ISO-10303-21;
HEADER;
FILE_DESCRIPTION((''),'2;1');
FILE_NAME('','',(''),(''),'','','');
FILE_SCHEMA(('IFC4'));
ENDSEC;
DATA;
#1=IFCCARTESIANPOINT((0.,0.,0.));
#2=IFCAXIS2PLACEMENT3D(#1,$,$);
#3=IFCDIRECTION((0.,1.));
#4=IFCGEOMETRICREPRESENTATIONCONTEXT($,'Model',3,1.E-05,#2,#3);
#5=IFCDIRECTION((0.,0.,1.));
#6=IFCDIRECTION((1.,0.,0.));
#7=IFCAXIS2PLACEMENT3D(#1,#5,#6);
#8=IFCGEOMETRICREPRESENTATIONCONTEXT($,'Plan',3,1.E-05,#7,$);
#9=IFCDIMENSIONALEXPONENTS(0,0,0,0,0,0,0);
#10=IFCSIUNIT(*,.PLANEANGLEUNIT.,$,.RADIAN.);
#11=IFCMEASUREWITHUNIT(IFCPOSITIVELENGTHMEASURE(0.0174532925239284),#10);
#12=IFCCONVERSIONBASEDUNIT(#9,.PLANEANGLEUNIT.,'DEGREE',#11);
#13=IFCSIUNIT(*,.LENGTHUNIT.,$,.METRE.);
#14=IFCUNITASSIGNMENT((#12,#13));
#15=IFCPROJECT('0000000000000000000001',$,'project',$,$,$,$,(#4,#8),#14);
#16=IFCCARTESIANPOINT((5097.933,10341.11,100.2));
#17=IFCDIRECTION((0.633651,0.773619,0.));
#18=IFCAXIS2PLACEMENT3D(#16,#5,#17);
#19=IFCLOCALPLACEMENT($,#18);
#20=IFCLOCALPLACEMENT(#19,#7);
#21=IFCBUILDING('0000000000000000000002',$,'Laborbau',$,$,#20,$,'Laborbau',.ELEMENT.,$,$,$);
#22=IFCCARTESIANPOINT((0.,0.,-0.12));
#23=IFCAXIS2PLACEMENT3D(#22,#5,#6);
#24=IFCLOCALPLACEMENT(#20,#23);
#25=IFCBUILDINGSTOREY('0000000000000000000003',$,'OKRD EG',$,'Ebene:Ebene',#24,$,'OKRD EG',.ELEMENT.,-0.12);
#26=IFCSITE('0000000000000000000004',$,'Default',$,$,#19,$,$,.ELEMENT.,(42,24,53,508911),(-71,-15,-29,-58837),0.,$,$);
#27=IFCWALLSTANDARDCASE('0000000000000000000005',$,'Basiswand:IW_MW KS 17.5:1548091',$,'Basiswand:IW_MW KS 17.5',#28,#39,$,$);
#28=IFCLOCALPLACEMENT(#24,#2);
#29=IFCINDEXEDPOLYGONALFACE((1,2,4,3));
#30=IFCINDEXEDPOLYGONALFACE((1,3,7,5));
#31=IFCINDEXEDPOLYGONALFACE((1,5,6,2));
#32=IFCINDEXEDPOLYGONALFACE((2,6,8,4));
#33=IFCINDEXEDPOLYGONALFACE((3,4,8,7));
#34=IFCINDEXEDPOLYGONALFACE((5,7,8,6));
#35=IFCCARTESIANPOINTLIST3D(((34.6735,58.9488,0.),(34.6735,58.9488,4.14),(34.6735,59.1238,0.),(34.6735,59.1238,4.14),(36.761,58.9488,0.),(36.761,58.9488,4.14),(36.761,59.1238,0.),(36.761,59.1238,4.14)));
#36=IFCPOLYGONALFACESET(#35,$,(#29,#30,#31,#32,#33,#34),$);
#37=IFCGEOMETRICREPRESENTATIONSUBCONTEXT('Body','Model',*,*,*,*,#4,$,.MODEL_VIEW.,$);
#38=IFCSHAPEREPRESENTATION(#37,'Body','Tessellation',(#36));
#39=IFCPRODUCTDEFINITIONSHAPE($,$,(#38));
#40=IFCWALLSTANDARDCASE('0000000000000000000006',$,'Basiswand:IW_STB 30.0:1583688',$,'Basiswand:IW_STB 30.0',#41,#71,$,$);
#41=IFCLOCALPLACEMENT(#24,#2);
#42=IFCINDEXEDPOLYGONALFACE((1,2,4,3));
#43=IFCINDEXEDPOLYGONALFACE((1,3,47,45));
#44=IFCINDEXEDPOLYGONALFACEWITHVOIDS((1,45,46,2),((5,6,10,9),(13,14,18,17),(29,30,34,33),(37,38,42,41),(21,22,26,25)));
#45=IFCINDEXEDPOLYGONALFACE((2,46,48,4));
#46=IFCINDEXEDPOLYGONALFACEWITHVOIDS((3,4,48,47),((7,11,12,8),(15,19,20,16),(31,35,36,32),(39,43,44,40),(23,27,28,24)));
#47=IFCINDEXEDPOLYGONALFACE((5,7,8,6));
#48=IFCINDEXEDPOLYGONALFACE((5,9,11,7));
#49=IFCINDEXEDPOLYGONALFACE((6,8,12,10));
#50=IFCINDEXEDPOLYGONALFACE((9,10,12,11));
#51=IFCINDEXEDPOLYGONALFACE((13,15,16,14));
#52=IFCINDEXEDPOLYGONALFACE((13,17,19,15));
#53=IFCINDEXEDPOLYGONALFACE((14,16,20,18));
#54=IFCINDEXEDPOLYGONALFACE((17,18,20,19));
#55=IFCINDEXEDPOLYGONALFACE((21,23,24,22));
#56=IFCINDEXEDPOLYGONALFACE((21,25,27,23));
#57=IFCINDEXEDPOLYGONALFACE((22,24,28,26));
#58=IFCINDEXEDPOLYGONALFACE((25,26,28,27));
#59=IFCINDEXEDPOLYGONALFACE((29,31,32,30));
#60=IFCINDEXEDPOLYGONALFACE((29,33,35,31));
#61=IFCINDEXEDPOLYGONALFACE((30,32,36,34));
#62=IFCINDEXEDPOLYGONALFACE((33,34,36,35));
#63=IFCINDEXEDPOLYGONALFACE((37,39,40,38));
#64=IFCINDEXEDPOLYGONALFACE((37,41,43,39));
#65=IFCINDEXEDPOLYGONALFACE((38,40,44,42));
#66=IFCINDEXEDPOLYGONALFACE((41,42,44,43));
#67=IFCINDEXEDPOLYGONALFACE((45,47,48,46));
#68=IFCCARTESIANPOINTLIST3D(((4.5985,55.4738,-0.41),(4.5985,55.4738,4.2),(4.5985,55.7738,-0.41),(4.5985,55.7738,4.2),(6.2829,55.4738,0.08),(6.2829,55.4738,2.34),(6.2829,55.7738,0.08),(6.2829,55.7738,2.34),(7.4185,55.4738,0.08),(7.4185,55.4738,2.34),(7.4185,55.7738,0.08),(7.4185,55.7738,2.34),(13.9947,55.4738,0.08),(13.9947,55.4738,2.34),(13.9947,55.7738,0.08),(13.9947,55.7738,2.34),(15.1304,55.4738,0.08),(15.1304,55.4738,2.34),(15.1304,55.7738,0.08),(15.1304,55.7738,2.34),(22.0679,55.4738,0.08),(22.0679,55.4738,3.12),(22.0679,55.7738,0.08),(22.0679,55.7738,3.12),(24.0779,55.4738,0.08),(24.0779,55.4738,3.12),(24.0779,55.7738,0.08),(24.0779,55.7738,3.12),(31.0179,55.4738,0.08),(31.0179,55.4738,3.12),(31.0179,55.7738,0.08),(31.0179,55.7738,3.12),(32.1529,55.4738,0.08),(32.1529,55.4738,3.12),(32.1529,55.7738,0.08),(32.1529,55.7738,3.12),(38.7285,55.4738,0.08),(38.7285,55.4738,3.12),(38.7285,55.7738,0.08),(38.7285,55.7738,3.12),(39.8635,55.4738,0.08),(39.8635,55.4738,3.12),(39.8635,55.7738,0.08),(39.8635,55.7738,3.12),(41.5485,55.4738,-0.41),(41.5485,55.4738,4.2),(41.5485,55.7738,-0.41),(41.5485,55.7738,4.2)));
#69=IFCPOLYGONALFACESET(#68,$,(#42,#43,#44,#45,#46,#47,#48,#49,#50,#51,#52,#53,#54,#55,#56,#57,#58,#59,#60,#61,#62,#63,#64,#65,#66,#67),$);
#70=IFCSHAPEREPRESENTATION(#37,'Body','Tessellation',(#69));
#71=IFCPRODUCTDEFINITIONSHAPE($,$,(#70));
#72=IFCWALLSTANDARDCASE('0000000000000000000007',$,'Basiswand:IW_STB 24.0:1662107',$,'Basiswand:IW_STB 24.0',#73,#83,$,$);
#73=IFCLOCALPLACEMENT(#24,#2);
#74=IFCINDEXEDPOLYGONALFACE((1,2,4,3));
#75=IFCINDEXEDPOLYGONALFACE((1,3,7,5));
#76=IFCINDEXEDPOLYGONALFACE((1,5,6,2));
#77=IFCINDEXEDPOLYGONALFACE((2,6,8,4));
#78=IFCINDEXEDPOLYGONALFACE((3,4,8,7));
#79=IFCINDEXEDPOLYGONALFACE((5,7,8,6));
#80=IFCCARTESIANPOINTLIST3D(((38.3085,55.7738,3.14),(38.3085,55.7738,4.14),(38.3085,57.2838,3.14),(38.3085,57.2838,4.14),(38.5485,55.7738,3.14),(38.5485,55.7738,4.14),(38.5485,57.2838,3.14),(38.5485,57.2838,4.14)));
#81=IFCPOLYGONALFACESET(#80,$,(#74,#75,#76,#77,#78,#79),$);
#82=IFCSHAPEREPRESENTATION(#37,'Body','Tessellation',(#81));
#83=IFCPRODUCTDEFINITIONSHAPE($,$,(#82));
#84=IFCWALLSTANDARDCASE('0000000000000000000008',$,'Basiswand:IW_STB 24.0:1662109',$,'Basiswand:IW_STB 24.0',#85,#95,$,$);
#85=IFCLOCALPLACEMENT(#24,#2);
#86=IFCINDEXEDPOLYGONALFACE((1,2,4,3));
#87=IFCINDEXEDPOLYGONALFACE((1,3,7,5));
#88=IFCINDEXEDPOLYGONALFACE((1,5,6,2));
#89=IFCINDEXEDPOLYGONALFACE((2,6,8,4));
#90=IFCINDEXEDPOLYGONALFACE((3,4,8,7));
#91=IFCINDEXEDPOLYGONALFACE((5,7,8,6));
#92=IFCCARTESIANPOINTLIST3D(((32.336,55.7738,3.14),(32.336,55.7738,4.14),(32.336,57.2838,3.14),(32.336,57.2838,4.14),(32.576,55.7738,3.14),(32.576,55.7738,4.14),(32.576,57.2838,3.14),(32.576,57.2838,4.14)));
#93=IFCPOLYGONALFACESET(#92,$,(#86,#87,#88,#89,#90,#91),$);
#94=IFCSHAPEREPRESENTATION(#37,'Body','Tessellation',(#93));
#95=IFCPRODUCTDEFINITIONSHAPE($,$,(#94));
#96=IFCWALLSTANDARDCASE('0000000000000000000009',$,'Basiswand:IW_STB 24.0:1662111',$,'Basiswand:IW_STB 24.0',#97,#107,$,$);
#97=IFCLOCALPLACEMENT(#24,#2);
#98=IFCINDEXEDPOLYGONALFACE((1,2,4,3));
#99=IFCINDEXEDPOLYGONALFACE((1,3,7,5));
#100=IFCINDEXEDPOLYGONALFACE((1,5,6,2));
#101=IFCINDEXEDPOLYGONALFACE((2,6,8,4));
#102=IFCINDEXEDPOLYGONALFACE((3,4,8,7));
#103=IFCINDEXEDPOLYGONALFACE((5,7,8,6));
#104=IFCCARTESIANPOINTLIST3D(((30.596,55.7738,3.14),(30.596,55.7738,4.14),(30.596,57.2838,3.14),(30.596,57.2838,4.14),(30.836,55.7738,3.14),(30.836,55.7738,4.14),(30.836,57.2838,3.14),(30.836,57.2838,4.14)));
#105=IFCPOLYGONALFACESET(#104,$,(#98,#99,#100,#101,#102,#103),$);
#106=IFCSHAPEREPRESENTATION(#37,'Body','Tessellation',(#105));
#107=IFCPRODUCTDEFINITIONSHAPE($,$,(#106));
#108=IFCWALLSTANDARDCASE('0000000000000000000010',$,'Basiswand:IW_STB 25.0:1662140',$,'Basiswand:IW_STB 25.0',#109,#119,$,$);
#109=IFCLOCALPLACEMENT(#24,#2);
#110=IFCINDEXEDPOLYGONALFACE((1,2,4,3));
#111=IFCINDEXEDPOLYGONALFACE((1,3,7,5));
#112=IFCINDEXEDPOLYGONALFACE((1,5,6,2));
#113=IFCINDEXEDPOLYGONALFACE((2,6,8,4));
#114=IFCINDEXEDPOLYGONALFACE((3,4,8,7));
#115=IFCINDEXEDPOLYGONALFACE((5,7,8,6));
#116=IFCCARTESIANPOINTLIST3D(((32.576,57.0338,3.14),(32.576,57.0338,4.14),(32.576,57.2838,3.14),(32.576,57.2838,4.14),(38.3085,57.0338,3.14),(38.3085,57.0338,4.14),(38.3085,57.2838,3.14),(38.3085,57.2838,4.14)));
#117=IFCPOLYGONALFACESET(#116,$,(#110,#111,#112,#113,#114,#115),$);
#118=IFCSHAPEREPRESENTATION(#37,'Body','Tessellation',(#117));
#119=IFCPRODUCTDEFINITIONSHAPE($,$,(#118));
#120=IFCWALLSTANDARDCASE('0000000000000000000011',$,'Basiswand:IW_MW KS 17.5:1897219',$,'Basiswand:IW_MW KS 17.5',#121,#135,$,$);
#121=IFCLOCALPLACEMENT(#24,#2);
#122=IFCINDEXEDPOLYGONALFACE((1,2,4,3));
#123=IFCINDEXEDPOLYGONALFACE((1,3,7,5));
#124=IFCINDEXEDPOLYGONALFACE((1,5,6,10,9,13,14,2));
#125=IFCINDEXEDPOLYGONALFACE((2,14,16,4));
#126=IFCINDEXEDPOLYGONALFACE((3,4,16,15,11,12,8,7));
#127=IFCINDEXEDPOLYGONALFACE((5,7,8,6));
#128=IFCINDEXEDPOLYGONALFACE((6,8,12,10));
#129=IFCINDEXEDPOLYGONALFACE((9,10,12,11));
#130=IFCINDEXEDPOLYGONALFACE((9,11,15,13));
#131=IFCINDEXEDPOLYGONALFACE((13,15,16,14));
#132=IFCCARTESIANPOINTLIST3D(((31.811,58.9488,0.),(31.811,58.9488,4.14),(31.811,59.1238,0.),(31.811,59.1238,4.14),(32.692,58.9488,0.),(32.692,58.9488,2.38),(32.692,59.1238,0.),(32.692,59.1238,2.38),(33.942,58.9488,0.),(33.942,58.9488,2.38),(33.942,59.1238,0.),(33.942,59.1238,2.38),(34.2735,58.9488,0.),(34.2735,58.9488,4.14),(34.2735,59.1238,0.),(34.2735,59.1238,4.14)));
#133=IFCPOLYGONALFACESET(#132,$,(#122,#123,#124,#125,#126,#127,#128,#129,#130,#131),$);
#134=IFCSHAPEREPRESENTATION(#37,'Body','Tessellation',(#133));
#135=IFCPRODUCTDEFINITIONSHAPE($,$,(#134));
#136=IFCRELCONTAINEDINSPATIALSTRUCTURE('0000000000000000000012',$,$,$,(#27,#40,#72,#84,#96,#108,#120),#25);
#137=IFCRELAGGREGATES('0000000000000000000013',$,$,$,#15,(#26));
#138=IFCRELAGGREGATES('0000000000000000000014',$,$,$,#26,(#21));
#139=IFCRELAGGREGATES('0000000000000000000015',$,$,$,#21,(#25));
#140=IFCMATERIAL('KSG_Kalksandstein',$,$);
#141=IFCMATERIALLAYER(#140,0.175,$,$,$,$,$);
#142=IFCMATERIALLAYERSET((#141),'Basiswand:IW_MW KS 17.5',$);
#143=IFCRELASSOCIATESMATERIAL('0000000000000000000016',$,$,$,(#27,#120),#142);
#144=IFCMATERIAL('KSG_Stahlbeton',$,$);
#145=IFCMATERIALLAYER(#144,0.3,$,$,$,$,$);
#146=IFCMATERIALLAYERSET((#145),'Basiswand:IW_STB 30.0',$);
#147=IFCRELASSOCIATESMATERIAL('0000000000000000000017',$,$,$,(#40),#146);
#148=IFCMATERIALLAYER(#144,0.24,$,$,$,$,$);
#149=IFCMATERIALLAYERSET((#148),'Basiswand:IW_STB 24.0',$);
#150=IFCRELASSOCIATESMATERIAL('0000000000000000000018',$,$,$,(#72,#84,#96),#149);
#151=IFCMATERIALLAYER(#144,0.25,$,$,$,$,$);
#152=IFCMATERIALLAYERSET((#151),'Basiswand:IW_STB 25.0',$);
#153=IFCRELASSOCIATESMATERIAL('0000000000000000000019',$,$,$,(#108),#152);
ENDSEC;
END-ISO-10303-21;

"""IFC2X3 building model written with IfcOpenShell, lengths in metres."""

from ifc_helpers import new_model, entity, si_unit, converted_unit, direction, frame, frame_2d, origin, origin_with_axes, origin_2d_with_axis, place, context, subcontext, project, spatial, rectangle, extrude, material, layer, layer_set, layer_usage, element, save


model = new_model("IFC2X3")

# Units and contexts
model_context = context("Model", 3, precision=1e-05, world=origin(), true_north=direction((0.0, 1.0)))
plan_context = context("Plan", 3, precision=1e-05, world=origin_with_axes())
body_context = subcontext(model_context, "Body", "Model", "MODEL_VIEW")
ifc_project = project(units=[converted_unit("PLANEANGLEUNIT", "DEGREE", entity("IfcPositiveLengthMeasure", 0.0174532925239284), si_unit("PLANEANGLEUNIT", "RADIAN"), dimensions=[0, 0, 0, 0, 0, 0, 0]), si_unit("LENGTHUNIT", "METRE")], contexts=[model_context, plan_context])

# Site, building, storey
site_placement = place(None, frame((5097.933, 10341.11, 100.2), z_axis=(0.0, 0.0, 1.0), x_axis=(0.633651, 0.773619, 0.0)))
site = spatial("IfcSite", under=ifc_project, at=site_placement, Name="Default", CompositionType="ELEMENT", RefLatitude=(42, 24, 53, 508911), RefLongitude=(-71, -15, -29, -58837), RefElevation=0.0)
building_placement = place(site_placement, origin_with_axes())
building = spatial("IfcBuilding", under=site, at=building_placement, Name="Laborbau", LongName="Laborbau", CompositionType="ELEMENT")
storey_placement = place(building_placement, frame((0.0, 0.0, -0.12), z_axis=(0.0, 0.0, 1.0), x_axis=(1.0, 0.0, 0.0)))
storey = spatial("IfcBuildingStorey", under=building, at=storey_placement, Name="OKRD EG", ObjectType="Ebene:Ebene", LongName="OKRD EG", CompositionType="ELEMENT", Elevation=-0.12)

# Wall
ifc_material_1 = material(Name="KSG_Kalksandstein")
ifc_layer_1 = layer(ifc_material_1, 0.175)
ifc_layer_set_1 = layer_set([ifc_layer_1], Name="Basiswand:IW_MW KS 17.5")
ifc_layer_usage_1 = layer_usage(ifc_layer_set_1, "AXIS2", "NEGATIVE", 0.0875)
wall_1_placement = place(storey_placement, frame((36.761, 59.0363, 0.0), z_axis=(0.0, 0.0, 1.0), x_axis=(-1.0, 0.0, 0.0)))
element("IfcWallStandardCase", 1, at=wall_1_placement, inside=storey, material=ifc_layer_usage_1, Name="Basiswand:IW_MW KS 17.5:1548091", ObjectType="Basiswand:IW_MW KS 17.5", context=body_context, shape_type="SweptSolid", body=[
    extrude(rectangle(XDim=2.0875, YDim=0.175, at=frame_2d((1.0438, 0.0), x_axis=(-1.0, 0.0))), origin(), (0.0, 0.0, 1.0), 4.14),
])

# Wall, openings
ifc_material_2 = material(Name="KSG_Stahlbeton")
ifc_layer_2 = layer(ifc_material_2, 0.3)
ifc_layer_set_2 = layer_set([ifc_layer_2], Name="Basiswand:IW_STB 30.0")
ifc_layer_usage_2 = layer_usage(ifc_layer_set_2, "AXIS2", "NEGATIVE", 0.15)
wall_2_placement = place(storey_placement, frame((41.5485, 55.6238, -0.41), z_axis=(0.0, 0.0, 1.0), x_axis=(-1.0, 0.0, 0.0)))
wall_2 = element("IfcWallStandardCase", 2, at=wall_2_placement, inside=storey, material=ifc_layer_usage_2, Name="Basiswand:IW_STB 30.0:1583688", ObjectType="Basiswand:IW_STB 30.0", context=body_context, shape_type="SweptSolid", body=[
    extrude(rectangle(XDim=36.95, YDim=0.3, at=frame_2d((18.475, 0.0), x_axis=(-1.0, 0.0))), origin(), (0.0, 0.0, 1.0), 4.61),
])
opening_1_placement = place(wall_2_placement, origin_with_axes())
element("IfcOpeningElement", 3, at=opening_1_placement, cuts=wall_2, ObjectType="Opening", context=body_context, shape_type="SweptSolid", body=[
    extrude(rectangle(XDim=2.26, YDim=1.1357, at=origin_2d_with_axis()), frame((26.986, -0.15, 1.62), z_axis=(0.0, 1.0, 0.0), x_axis=(0.0, 0.0, -1.0)), (0.0, 0.0, 1.0), 0.3),
])
opening_2_placement = place(wall_2_placement, origin_with_axes())
element("IfcOpeningElement", 4, at=opening_2_placement, cuts=wall_2, ObjectType="Opening", context=body_context, shape_type="SweptSolid", body=[
    extrude(rectangle(XDim=2.26, YDim=1.1357, at=origin_2d_with_axis()), frame((34.6978, -0.15, 1.62), z_axis=(0.0, 1.0, 0.0), x_axis=(0.0, 0.0, -1.0)), (0.0, 0.0, 1.0), 0.3),
])
opening_3_placement = place(wall_2_placement, frame((41.5485, 55.6238, 0.41), z_axis=(0.0, 0.0, 1.0), x_axis=(-1.0, 0.0, 0.0)))
element("IfcOpeningElement", 5, at=opening_3_placement, cuts=wall_2, ObjectType="Opening", context=body_context, shape_type="SweptSolid", body=[
    extrude(rectangle(XDim=3.04, YDim=2.01, at=origin_2d_with_axis()), frame((23.0729, 57.2978, 1.6), z_axis=(0.0, -1.0, 0.0), x_axis=(0.0, 0.0, 1.0)), (0.0, 0.0, 1.0), 3.048),
])
opening_4_placement = place(wall_2_placement, frame((19.4807, 0.15, 0.49), z_axis=(0.0, 0.0, 1.0), x_axis=(1.0, 0.0, 0.0)))
element("IfcOpeningElement", 6, at=opening_4_placement, cuts=wall_2, ObjectType="Opening", context=body_context, shape_type="SweptSolid", body=[
    extrude(rectangle(XDim=3.04, YDim=2.01, at=frame_2d((1.52, 1.005), x_axis=(1.0, 0.0))), frame((0.0, 0.0, 0.0), z_axis=(0.0, -1.0, 0.0), x_axis=(0.0, 0.0, 1.0)), (0.0, 0.0, 1.0), 0.3),
])
opening_5_placement = place(wall_2_placement, frame((41.5485, 55.6238, 0.41), z_axis=(0.0, 0.0, 1.0), x_axis=(-1.0, 0.0, 0.0)))
element("IfcOpeningElement", 7, at=opening_5_placement, cuts=wall_2, ObjectType="Opening", context=body_context, shape_type="SweptSolid", body=[
    extrude(rectangle(XDim=3.04, YDim=1.135, at=frame_2d((0.0, 0.0), x_axis=(1.0, 0.0))), frame((31.5854, 57.2978, 1.6), z_axis=(0.0, -1.0, 0.0), x_axis=(0.0, 0.0, 1.0)), (0.0, 0.0, 1.0), 3.048),
])
opening_6_placement = place(wall_2_placement, frame((10.5307, 0.15, 0.49), z_axis=(0.0, 0.0, 1.0), x_axis=(1.0, 0.0, 0.0)))
element("IfcOpeningElement", 8, at=opening_6_placement, cuts=wall_2, ObjectType="Opening", context=body_context, shape_type="SweptSolid", body=[
    extrude(rectangle(XDim=3.04, YDim=1.135, at=frame_2d((1.52, 0.5675), x_axis=(1.0, 0.0))), frame((0.0, 0.0, 0.0), z_axis=(0.0, -1.0, 0.0), x_axis=(0.0, 0.0, 1.0)), (0.0, 0.0, 1.0), 0.3),
])
opening_7_placement = place(wall_2_placement, frame((41.5485, 55.6238, 0.41), z_axis=(0.0, 0.0, 1.0), x_axis=(-1.0, 0.0, 0.0)))
element("IfcOpeningElement", 9, at=opening_7_placement, cuts=wall_2, ObjectType="Opening", context=body_context, shape_type="SweptSolid", body=[
    extrude(rectangle(XDim=3.04, YDim=1.135, at=frame_2d((0.0, 0.0), x_axis=(0.0, 1.0))), frame((39.296, 56.9978, 1.6), z_axis=(0.0, -1.0, 0.0), x_axis=(1.0, 0.0, 0.0)), (0.0, 0.0, 1.0), 3.048),
])
opening_8_placement = place(wall_2_placement, frame((1.685, -0.15, 0.49), z_axis=(0.0, 0.0, 1.0), x_axis=(1.0, 0.0, 0.0)))
element("IfcOpeningElement", 10, at=opening_8_placement, cuts=wall_2, ObjectType="Opening", context=body_context, shape_type="SweptSolid", body=[
    extrude(rectangle(XDim=3.04, YDim=1.135, at=frame_2d((1.52, 0.5675), x_axis=(1.0, 0.0))), frame((0.0, 0.0, 0.0), z_axis=(0.0, 1.0, 0.0), x_axis=(0.0, 0.0, 1.0)), (0.0, 0.0, 1.0), 0.3),
])

# Walls
ifc_layer_3 = layer(ifc_material_2, 0.24)
ifc_layer_set_3 = layer_set([ifc_layer_3], Name="Basiswand:IW_STB 24.0")
ifc_layer_usage_3 = layer_usage(ifc_layer_set_3, "AXIS2", "POSITIVE", -0.12)
wall_3_placement = place(storey_placement, frame((38.4285, 55.7738, 3.14), z_axis=(0.0, 0.0, 1.0), x_axis=(0.0, 1.0, 0.0)))
element("IfcWallStandardCase", 11, at=wall_3_placement, inside=storey, material=ifc_layer_usage_3, Name="Basiswand:IW_STB 24.0:1662107", ObjectType="Basiswand:IW_STB 24.0", context=body_context, shape_type="SweptSolid", body=[
    extrude(rectangle(XDim=1.51, YDim=0.24, at=frame_2d((0.755, 0.0), x_axis=(-1.0, 0.0))), origin(), (0.0, 0.0, 1.0), 1.0),
])
ifc_layer_usage_4 = layer_usage(ifc_layer_set_3, "AXIS2", "POSITIVE", -0.12)
wall_4_placement = place(storey_placement, frame((32.456, 57.2838, 3.14), z_axis=(0.0, 0.0, 1.0), x_axis=(0.0, -1.0, 0.0)))
element("IfcWallStandardCase", 12, at=wall_4_placement, inside=storey, material=ifc_layer_usage_4, Name="Basiswand:IW_STB 24.0:1662109", ObjectType="Basiswand:IW_STB 24.0", context=body_context, shape_type="SweptSolid", body=[
    extrude(rectangle(XDim=1.51, YDim=0.24, at=frame_2d((0.755, 0.0), x_axis=(-1.0, 0.0))), origin(), (0.0, 0.0, 1.0), 1.0),
])
ifc_layer_usage_5 = layer_usage(ifc_layer_set_3, "AXIS2", "POSITIVE", -0.12)
wall_5_placement = place(storey_placement, frame((30.716, 55.7738, 3.14), z_axis=(0.0, 0.0, 1.0), x_axis=(0.0, 1.0, 0.0)))
element("IfcWallStandardCase", 13, at=wall_5_placement, inside=storey, material=ifc_layer_usage_5, Name="Basiswand:IW_STB 24.0:1662111", ObjectType="Basiswand:IW_STB 24.0", context=body_context, shape_type="SweptSolid", body=[
    extrude(rectangle(XDim=1.51, YDim=0.24, at=frame_2d((0.755, 0.0), x_axis=(-1.0, 0.0))), origin(), (0.0, 0.0, 1.0), 1.0),
])
ifc_layer_4 = layer(ifc_material_2, 0.25)
ifc_layer_set_4 = layer_set([ifc_layer_4], Name="Basiswand:IW_STB 25.0")
ifc_layer_usage_6 = layer_usage(ifc_layer_set_4, "AXIS2", "NEGATIVE", 0.125)
wall_6_placement = place(storey_placement, frame((32.576, 57.1588, 3.14), z_axis=(0.0, 0.0, 1.0), x_axis=(1.0, 0.0, 0.0)))
element("IfcWallStandardCase", 14, at=wall_6_placement, inside=storey, material=ifc_layer_usage_6, Name="Basiswand:IW_STB 25.0:1662140", ObjectType="Basiswand:IW_STB 25.0", context=body_context, shape_type="SweptSolid", body=[
    extrude(rectangle(XDim=5.7325, YDim=0.25, at=frame_2d((2.8662, 0.0), x_axis=(-1.0, 0.0))), origin(), (0.0, 0.0, 1.0), 1.0),
])

# Wall, openings
ifc_layer_usage_7 = layer_usage(ifc_layer_set_1, "AXIS2", "NEGATIVE", 0.0875)
wall_7_placement = place(storey_placement, frame((34.2735, 59.0363, 0.0), z_axis=(0.0, 0.0, 1.0), x_axis=(-1.0, 0.0, 0.0)))
wall_7 = element("IfcWallStandardCase", 15, at=wall_7_placement, inside=storey, material=ifc_layer_usage_7, Name="Basiswand:IW_MW KS 17.5:1897219", ObjectType="Basiswand:IW_MW KS 17.5", context=body_context, shape_type="SweptSolid", body=[
    extrude(rectangle(XDim=2.4625, YDim=0.175, at=frame_2d((1.2312, 0.0), x_axis=(-1.0, 0.0))), origin(), (0.0, 0.0, 1.0), 4.14),
])
opening_9_placement = place(wall_7_placement, frame((0.3315, -0.0875, 0.0), z_axis=(0.0, 0.0, 1.0), x_axis=(1.0, 0.0, 0.0)))
element("IfcOpeningElement", 16, at=opening_9_placement, cuts=wall_7, ObjectType="Opening", context=body_context, shape_type="SweptSolid", body=[
    extrude(rectangle(XDim=2.38, YDim=1.25, at=frame_2d((1.19, 0.625), x_axis=(1.0, 0.0))), frame((0.0, 0.0, 0.0), z_axis=(0.0, 1.0, 0.0), x_axis=(0.0, 0.0, 1.0)), (0.0, 0.0, 1.0), 0.175),
])
opening_10_placement = place(wall_7_placement, frame((34.2735, 59.0363, 0.0), z_axis=(0.0, 0.0, 1.0), x_axis=(-1.0, 0.0, 0.0)))
element("IfcOpeningElement", 17, at=opening_10_placement, cuts=wall_7, ObjectType="Opening", context=body_context, shape_type="SweptSolid", body=[
    extrude(rectangle(XDim=2.38, YDim=1.25, at=frame_2d((0.0, 0.0), x_axis=(0.0, 1.0))), frame((33.317, 60.6478, 1.19), z_axis=(0.0, -1.0, 0.0), x_axis=(1.0, 0.0, 0.0)), (0.0, 0.0, 1.0), 3.048),
])

save(model, "model.ifc")
